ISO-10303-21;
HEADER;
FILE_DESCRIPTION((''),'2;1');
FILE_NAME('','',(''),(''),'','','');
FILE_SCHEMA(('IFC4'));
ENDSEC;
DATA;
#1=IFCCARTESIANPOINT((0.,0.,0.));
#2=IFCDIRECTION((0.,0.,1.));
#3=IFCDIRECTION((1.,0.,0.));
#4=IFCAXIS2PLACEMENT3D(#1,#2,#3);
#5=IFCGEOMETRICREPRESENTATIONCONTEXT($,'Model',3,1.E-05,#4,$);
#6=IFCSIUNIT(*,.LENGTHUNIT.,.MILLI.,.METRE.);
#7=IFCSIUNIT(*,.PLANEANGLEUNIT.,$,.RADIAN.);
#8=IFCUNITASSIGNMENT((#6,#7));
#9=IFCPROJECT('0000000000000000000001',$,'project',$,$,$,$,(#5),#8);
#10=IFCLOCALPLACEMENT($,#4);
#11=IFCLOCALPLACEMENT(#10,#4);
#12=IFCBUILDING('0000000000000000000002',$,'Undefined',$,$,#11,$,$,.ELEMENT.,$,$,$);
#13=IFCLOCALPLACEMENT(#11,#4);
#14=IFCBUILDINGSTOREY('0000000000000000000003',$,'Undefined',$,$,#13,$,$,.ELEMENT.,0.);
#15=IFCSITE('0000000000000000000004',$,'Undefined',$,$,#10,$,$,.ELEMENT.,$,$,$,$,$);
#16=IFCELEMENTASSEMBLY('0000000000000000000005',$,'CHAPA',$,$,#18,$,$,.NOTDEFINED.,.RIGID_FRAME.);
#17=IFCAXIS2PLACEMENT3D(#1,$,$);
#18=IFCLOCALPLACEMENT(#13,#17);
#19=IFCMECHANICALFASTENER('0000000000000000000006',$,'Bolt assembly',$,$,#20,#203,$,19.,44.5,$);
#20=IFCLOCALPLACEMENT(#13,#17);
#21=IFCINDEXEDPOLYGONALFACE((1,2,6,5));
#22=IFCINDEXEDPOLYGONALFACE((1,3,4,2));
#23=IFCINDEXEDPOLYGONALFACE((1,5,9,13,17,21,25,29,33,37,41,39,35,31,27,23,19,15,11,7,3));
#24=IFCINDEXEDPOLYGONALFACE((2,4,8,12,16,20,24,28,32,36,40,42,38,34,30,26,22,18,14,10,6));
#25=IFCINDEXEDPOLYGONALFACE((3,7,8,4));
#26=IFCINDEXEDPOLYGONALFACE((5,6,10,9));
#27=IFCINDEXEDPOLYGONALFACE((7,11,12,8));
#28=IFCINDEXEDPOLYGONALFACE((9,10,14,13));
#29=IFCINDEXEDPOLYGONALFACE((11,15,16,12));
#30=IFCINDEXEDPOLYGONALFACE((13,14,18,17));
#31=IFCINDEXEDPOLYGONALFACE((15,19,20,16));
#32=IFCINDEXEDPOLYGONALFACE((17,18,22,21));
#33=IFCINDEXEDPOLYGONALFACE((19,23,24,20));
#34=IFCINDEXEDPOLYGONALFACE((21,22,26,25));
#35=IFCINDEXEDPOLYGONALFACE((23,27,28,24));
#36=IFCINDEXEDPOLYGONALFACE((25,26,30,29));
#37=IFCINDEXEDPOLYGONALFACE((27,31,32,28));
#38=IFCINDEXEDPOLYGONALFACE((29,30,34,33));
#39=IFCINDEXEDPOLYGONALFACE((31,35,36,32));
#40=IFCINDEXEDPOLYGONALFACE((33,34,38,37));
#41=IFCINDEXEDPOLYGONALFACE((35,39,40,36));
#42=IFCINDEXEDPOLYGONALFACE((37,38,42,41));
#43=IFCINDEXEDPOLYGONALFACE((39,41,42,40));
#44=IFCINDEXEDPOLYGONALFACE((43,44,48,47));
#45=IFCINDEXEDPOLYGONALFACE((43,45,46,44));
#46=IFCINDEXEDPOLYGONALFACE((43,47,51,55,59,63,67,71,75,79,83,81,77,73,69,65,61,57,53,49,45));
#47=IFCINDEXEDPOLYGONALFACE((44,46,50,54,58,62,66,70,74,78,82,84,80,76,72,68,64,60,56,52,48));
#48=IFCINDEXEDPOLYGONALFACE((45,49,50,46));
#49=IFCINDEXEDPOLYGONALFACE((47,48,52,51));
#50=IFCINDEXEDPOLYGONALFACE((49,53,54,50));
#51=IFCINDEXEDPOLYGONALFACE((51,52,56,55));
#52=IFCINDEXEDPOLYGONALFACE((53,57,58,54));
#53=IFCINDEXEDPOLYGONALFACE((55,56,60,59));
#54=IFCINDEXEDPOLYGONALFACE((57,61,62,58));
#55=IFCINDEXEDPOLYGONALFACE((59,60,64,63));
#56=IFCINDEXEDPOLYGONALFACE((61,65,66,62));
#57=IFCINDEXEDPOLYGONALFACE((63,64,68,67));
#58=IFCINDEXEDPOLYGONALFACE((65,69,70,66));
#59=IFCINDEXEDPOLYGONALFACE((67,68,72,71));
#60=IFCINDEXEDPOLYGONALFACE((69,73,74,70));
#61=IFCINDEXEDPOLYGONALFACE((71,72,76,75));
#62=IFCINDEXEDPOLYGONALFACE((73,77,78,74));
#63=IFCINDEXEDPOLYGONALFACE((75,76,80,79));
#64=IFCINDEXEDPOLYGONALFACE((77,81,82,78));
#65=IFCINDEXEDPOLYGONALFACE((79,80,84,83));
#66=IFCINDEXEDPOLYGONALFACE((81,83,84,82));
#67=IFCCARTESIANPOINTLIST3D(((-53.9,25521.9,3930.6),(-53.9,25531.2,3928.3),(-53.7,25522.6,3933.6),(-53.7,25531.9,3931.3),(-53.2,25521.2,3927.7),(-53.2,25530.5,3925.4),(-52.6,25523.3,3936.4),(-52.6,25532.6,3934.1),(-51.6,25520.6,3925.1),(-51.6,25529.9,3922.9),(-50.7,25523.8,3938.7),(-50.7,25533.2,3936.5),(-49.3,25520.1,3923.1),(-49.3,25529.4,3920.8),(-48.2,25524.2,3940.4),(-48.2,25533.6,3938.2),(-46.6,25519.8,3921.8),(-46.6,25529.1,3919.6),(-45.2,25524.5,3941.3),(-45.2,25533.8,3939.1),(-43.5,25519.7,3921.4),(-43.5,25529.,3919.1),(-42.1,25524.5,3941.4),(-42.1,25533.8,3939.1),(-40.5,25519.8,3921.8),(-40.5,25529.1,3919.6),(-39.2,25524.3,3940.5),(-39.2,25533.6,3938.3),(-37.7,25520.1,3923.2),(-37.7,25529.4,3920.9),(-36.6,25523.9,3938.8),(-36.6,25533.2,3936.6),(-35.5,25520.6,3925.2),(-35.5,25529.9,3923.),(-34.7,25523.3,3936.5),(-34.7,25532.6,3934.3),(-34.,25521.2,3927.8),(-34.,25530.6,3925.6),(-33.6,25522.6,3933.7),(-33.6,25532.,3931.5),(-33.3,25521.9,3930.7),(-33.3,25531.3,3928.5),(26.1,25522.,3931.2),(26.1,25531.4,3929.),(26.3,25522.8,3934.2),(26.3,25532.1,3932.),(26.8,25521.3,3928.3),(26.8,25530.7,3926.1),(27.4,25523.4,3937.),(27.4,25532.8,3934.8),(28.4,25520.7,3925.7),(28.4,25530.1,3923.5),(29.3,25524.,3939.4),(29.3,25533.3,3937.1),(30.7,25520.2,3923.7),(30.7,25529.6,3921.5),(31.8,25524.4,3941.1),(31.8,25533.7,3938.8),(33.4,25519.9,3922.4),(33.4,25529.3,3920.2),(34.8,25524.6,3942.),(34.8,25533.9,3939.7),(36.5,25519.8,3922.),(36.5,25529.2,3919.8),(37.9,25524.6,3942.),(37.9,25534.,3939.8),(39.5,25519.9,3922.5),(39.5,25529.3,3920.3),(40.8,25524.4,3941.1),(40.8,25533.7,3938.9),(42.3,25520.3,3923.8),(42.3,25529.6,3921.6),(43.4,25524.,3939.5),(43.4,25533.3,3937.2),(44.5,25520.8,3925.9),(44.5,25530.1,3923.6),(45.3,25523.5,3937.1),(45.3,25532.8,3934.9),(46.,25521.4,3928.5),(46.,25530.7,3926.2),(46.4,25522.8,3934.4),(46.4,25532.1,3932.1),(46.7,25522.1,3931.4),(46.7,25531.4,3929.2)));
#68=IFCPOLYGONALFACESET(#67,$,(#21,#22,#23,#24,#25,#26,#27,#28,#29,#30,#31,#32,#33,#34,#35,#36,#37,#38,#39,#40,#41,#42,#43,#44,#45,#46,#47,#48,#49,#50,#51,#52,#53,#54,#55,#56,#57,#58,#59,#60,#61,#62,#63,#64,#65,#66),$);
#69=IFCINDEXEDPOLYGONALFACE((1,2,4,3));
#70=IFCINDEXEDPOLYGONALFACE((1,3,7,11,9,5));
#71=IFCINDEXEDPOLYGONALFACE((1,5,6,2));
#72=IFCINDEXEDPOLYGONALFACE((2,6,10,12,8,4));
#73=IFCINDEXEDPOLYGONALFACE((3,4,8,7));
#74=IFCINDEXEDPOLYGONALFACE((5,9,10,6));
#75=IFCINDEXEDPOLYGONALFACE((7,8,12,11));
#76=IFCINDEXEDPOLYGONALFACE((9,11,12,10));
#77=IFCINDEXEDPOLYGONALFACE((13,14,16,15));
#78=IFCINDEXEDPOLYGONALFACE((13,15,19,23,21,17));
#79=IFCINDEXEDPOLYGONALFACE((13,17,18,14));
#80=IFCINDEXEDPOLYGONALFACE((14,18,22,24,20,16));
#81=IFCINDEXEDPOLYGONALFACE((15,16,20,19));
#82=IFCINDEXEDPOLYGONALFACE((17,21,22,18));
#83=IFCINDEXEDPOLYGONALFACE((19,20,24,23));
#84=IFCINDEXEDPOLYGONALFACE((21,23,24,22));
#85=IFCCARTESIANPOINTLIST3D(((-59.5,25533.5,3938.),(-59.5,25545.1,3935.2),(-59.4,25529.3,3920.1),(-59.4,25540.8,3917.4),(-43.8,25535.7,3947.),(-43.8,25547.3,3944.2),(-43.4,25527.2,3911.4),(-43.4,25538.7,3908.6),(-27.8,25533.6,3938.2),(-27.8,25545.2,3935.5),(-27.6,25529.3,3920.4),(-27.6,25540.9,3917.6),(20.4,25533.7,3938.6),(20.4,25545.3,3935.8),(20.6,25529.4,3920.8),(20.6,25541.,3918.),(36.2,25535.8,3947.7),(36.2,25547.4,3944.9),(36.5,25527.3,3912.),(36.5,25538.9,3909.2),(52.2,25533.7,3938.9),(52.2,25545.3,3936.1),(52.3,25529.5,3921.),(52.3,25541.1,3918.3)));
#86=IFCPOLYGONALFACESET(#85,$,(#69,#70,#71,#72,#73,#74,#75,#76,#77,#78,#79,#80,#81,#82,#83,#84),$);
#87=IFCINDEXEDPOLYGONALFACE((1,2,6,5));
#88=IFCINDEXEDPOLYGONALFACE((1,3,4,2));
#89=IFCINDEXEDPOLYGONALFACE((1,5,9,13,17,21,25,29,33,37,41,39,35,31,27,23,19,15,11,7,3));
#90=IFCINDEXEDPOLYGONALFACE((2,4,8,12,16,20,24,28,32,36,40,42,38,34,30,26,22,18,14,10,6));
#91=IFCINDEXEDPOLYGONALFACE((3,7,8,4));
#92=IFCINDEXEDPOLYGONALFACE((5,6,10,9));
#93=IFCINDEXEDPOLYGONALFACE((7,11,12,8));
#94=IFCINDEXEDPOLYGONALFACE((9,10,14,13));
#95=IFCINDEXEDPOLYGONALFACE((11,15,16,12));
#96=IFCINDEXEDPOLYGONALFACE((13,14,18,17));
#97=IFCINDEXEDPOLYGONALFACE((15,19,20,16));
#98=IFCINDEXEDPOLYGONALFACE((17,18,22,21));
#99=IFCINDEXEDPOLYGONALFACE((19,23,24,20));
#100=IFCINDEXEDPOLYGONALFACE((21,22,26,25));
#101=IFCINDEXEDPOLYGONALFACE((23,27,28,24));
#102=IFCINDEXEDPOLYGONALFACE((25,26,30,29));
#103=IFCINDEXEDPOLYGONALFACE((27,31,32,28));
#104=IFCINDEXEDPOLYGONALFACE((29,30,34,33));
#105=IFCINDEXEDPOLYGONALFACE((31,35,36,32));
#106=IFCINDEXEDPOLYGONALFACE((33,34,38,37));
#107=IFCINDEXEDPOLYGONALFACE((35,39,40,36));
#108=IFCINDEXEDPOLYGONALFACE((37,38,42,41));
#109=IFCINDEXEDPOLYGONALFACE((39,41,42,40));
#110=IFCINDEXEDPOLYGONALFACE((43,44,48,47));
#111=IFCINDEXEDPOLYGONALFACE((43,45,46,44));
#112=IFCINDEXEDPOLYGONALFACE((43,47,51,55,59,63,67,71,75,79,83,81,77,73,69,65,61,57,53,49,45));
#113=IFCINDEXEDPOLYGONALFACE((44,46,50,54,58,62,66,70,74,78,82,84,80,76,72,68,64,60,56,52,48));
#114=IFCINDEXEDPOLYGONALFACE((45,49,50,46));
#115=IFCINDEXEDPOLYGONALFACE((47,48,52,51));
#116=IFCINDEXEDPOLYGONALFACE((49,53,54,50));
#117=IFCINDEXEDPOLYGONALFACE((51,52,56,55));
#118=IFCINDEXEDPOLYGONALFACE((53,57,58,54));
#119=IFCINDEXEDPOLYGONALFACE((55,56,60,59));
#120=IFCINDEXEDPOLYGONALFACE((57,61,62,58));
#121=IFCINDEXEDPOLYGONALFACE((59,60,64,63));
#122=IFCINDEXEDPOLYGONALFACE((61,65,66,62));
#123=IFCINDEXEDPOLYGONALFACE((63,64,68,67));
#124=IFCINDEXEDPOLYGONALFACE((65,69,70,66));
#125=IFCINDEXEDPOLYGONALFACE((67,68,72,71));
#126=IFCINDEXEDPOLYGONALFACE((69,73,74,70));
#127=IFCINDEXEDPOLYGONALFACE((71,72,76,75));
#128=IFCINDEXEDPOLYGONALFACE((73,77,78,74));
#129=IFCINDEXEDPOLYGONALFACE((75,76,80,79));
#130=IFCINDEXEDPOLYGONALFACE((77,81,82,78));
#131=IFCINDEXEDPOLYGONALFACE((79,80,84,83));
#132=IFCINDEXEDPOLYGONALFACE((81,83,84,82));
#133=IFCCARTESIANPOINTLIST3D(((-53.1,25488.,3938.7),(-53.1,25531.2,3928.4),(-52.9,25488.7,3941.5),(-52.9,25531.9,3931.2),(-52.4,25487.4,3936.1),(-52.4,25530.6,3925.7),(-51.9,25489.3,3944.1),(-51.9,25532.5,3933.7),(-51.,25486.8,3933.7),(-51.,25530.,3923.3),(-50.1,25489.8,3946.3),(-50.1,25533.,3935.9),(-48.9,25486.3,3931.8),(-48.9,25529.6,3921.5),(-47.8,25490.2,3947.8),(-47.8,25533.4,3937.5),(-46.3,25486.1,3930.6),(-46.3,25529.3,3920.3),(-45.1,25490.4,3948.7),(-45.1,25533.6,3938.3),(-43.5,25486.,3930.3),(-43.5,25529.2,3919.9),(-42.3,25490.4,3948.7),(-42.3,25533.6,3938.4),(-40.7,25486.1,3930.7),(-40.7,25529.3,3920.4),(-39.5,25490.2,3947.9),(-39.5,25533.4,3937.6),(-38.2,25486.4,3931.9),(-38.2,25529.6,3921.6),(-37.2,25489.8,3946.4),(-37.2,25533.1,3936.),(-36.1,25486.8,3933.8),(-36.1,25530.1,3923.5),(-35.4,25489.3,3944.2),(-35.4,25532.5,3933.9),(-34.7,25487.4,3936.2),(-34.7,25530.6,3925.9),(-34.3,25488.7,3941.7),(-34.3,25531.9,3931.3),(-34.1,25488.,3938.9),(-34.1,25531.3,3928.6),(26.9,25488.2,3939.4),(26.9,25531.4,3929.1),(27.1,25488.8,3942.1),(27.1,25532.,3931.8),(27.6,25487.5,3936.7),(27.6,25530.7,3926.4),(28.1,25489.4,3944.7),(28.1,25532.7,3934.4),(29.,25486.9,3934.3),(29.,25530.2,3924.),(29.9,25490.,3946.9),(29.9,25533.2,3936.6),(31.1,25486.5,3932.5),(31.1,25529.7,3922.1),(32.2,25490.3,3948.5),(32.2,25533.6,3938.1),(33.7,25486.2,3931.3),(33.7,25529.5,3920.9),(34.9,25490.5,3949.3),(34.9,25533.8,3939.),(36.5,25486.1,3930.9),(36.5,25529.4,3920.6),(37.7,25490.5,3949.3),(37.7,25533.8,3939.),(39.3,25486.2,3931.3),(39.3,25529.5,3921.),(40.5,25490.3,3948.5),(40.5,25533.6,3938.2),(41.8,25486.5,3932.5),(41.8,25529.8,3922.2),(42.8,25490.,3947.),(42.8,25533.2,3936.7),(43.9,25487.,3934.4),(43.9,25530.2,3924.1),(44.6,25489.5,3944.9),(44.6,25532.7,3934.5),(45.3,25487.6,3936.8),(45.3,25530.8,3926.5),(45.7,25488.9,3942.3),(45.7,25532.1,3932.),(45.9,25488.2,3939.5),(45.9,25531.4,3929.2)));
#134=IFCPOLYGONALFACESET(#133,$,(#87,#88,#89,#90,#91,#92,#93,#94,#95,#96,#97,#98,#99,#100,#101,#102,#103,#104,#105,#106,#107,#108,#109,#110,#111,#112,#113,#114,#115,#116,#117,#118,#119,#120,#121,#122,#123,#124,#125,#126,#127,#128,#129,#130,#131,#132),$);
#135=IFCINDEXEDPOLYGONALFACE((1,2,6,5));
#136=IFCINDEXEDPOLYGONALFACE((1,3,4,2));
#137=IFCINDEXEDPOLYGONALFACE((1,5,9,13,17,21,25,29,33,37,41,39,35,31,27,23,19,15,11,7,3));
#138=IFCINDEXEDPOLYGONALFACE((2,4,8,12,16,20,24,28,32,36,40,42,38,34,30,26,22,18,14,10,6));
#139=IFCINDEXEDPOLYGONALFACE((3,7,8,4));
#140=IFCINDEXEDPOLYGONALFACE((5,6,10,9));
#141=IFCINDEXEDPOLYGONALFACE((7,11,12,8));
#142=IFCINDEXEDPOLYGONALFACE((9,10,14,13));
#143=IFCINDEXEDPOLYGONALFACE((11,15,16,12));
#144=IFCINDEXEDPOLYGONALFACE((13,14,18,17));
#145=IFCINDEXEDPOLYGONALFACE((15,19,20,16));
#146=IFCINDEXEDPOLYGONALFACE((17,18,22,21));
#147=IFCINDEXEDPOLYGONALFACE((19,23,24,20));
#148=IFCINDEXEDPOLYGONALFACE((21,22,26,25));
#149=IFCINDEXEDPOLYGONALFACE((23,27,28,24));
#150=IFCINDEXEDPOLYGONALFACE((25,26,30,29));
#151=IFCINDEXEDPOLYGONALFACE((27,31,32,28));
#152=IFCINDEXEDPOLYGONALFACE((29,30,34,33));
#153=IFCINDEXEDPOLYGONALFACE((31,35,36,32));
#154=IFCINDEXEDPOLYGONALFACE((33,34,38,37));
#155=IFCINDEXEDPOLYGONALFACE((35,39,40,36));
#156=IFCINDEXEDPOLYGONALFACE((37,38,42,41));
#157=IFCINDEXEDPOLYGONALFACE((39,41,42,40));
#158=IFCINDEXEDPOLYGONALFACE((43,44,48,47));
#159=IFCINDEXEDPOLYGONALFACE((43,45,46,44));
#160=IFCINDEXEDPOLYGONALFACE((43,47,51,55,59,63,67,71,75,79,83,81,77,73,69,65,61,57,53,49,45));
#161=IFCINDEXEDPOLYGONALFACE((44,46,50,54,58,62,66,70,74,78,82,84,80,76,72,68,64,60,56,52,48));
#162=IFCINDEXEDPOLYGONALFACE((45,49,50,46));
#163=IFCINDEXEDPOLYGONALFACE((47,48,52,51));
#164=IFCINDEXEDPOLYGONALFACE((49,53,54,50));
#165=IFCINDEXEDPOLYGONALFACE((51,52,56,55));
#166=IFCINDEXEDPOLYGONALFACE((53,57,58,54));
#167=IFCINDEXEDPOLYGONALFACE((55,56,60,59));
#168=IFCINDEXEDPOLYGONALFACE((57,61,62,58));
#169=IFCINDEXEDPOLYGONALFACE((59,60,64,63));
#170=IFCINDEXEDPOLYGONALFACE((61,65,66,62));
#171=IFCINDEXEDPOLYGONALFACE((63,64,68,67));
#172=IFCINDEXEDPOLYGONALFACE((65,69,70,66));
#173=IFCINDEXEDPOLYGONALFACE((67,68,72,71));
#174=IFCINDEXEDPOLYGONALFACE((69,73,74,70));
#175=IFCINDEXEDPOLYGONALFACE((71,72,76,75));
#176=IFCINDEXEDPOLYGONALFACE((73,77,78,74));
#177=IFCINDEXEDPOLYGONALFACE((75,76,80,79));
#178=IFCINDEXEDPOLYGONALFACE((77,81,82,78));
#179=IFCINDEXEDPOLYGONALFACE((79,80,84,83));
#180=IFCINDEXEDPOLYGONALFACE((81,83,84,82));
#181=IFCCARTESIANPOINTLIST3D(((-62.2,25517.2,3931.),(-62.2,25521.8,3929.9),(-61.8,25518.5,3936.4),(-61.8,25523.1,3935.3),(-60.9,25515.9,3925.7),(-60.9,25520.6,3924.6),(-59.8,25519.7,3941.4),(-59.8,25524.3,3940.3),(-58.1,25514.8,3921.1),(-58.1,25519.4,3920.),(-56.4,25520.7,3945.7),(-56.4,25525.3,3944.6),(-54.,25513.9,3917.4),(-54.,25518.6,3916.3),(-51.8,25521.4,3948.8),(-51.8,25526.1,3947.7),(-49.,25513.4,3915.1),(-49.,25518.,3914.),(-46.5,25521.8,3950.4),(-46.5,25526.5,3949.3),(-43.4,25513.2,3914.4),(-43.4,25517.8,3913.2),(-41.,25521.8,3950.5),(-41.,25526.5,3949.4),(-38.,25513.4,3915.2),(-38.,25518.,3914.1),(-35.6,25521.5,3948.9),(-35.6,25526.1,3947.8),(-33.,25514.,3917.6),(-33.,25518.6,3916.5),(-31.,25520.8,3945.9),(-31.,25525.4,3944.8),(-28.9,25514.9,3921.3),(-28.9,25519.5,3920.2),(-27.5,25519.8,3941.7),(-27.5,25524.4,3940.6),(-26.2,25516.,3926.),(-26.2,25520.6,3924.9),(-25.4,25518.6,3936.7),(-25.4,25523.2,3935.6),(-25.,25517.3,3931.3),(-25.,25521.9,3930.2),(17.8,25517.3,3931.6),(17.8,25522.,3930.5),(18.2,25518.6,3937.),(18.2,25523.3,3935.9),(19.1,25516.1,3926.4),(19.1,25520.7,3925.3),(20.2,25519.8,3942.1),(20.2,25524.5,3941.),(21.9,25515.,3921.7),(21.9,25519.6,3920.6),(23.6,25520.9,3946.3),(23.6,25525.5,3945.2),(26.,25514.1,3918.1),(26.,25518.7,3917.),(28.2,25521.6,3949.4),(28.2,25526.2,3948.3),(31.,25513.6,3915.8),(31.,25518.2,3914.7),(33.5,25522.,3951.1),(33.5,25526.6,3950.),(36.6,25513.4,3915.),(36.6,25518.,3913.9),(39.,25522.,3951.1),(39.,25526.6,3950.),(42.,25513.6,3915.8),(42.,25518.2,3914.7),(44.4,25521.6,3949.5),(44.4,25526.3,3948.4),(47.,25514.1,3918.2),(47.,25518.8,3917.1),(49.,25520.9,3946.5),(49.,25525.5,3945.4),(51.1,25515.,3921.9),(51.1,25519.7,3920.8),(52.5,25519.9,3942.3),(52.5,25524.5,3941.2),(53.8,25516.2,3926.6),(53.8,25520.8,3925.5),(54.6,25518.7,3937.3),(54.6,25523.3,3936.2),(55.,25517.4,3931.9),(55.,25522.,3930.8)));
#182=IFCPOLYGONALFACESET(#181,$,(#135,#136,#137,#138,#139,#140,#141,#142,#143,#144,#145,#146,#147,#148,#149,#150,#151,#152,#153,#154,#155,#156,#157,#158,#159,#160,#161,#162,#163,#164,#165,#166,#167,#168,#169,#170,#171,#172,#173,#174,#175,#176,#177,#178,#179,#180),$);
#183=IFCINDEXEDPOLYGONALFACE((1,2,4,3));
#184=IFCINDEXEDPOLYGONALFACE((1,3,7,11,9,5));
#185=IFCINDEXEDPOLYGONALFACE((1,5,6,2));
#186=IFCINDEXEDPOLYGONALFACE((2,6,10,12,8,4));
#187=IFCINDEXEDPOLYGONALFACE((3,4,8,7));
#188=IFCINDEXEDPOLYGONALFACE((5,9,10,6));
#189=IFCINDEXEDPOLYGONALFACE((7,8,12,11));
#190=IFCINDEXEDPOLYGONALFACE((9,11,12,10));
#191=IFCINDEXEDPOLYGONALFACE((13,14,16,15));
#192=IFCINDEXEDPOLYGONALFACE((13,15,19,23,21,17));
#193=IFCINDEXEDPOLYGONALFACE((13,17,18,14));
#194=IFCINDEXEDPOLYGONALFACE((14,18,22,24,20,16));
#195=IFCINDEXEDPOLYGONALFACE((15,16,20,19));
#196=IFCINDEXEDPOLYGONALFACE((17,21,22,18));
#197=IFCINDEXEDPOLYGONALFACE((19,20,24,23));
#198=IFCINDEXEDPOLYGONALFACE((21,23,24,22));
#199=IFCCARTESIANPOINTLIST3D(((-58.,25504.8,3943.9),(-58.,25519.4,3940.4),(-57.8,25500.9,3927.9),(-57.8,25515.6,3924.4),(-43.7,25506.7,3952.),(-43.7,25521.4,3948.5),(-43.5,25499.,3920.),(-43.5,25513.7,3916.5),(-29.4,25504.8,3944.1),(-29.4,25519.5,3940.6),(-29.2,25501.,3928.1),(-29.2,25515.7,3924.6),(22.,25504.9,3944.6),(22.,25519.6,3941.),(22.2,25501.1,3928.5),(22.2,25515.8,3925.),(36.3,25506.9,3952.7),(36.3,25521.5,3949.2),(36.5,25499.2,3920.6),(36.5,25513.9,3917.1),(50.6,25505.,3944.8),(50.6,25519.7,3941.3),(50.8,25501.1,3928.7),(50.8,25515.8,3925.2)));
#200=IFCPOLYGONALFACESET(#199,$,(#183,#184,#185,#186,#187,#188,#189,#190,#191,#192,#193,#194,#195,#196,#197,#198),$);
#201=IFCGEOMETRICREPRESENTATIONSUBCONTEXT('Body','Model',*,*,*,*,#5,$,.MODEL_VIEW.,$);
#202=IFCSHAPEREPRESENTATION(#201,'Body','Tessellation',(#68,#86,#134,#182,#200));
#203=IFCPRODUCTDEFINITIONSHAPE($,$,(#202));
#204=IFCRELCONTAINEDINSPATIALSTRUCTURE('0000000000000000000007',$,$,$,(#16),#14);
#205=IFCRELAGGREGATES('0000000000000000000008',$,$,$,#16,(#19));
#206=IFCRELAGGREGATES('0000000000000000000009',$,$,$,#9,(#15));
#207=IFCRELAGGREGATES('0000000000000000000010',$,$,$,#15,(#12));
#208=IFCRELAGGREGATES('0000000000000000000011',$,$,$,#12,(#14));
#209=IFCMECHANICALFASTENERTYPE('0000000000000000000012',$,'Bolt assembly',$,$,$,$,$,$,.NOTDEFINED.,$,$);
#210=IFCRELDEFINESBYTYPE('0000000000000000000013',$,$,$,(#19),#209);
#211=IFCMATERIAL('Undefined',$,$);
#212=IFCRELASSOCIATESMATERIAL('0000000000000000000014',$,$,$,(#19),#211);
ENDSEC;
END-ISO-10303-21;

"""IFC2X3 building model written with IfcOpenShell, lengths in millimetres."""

from ifc_helpers import new_model, si_unit, frame, origin_with_axes, origin_2d_with_axis, place, context, subcontext, project, spatial, polyline, circle, outline, extrude, source, transform, mapped, material, type_object, element, aggregate, save


model = new_model("IFC2X3")

# Units and contexts
model_context = context("Model", 3, precision=1e-05, world=origin_with_axes())
body_context = subcontext(model_context, "Body", "Model", "MODEL_VIEW")
ifc_project = project(units=[si_unit("LENGTHUNIT", "METRE", prefix="MILLI"), si_unit("PLANEANGLEUNIT", "RADIAN")], contexts=[model_context])

# Site, building, storey
site_placement = place(None, origin_with_axes())
site = spatial("IfcSite", under=ifc_project, at=site_placement, Name="Undefined", CompositionType="ELEMENT")
building_placement = place(site_placement, origin_with_axes())
building = spatial("IfcBuilding", under=site, at=building_placement, Name="Undefined", CompositionType="ELEMENT")
storey_placement = place(building_placement, origin_with_axes())
storey = spatial("IfcBuildingStorey", under=building, at=storey_placement, Name="Undefined", CompositionType="ELEMENT", Elevation=0.0)

# Element assembly
assembly_1_placement = place(storey_placement, origin_with_axes())
assembly_1 = element("IfcElementAssembly", 1, at=assembly_1_placement, inside=storey, Name="CHAPA", AssemblyPlace="NOTDEFINED", PredefinedType="RIGID_FRAME")

# Shared definitions
ifc_material_1 = material(Name="Undefined")
mechanical_fastener_type = type_object("IfcMechanicalFastenerType", Name="Bolt assembly")

# Mechanical fastener
shared_shape_1 = source(origin_with_axes(), body_context, "Body", "SweptSolid", [
    extrude(circle(Radius=10.3, at=origin_2d_with_axis()), frame((0.0, 0.0, 0.0), z_axis=(0.0, 1.0, 0.0), x_axis=(1.0, 0.0, 0.0)), (0.0, 0.0, 1.0), 9.6),
    extrude(outline(polyline([(18.3, 0.0), (9.2, 15.9), (-9.2, 15.9), (-18.3, 0.0), (-9.2, -15.9), (9.2, -15.9), (18.3, 0.0)])), frame((0.0, -11.9, 0.0), z_axis=(0.0, 1.0, 0.0), x_axis=(1.0, 0.0, 0.0)), (0.0, 0.0, 1.0), 11.9),
    extrude(circle(Radius=9.5, at=origin_2d_with_axis()), frame((0.0, 0.0, 0.0), z_axis=(0.0, 1.0, 0.0), x_axis=(1.0, 0.0, 0.0)), (0.0, 0.0, 1.0), 44.5),
    extrude(circle(Radius=18.7, at=origin_2d_with_axis()), frame((0.0, 9.5, 0.0), z_axis=(0.0, 1.0, 0.0), x_axis=(1.0, 0.0, 0.0)), (0.0, 0.0, 1.0), 4.8),
    extrude(outline(polyline([(16.5, 0.0), (8.2, 14.3), (-8.2, 14.3), (-16.5, 0.0), (-8.2, -14.3), (8.2, -14.3), (16.5, 0.0)])), frame((0.0, 14.3, 0.0), z_axis=(0.0, 1.0, 0.0), x_axis=(1.0, 0.0, 0.0)), (0.0, 0.0, 1.0), 15.1),
])
mechanical_fastener_1_placement = place(assembly_1_placement, frame((-3.6, 25531.5, 3929.5), z_axis=(-0.999966, -0.001919, -0.008026), x_axis=(0.008253, -0.23249, -0.972564)))
mechanical_fastener_1 = element("IfcMechanicalFastener", 2, at=mechanical_fastener_1_placement, type_object=mechanical_fastener_type, material=ifc_material_1, Name="Bolt assembly", NominalDiameter=19.0, NominalLength=44.5, context=body_context, shape_type="MappedRepresentation", body=[
    mapped(shared_shape_1, transform((0.0, 0.0, 40.0))),
    mapped(shared_shape_1, transform((0.0, 0.0, -40.0))),
])
aggregate(assembly_1, [mechanical_fastener_1])

save(model, "model.ifc")
